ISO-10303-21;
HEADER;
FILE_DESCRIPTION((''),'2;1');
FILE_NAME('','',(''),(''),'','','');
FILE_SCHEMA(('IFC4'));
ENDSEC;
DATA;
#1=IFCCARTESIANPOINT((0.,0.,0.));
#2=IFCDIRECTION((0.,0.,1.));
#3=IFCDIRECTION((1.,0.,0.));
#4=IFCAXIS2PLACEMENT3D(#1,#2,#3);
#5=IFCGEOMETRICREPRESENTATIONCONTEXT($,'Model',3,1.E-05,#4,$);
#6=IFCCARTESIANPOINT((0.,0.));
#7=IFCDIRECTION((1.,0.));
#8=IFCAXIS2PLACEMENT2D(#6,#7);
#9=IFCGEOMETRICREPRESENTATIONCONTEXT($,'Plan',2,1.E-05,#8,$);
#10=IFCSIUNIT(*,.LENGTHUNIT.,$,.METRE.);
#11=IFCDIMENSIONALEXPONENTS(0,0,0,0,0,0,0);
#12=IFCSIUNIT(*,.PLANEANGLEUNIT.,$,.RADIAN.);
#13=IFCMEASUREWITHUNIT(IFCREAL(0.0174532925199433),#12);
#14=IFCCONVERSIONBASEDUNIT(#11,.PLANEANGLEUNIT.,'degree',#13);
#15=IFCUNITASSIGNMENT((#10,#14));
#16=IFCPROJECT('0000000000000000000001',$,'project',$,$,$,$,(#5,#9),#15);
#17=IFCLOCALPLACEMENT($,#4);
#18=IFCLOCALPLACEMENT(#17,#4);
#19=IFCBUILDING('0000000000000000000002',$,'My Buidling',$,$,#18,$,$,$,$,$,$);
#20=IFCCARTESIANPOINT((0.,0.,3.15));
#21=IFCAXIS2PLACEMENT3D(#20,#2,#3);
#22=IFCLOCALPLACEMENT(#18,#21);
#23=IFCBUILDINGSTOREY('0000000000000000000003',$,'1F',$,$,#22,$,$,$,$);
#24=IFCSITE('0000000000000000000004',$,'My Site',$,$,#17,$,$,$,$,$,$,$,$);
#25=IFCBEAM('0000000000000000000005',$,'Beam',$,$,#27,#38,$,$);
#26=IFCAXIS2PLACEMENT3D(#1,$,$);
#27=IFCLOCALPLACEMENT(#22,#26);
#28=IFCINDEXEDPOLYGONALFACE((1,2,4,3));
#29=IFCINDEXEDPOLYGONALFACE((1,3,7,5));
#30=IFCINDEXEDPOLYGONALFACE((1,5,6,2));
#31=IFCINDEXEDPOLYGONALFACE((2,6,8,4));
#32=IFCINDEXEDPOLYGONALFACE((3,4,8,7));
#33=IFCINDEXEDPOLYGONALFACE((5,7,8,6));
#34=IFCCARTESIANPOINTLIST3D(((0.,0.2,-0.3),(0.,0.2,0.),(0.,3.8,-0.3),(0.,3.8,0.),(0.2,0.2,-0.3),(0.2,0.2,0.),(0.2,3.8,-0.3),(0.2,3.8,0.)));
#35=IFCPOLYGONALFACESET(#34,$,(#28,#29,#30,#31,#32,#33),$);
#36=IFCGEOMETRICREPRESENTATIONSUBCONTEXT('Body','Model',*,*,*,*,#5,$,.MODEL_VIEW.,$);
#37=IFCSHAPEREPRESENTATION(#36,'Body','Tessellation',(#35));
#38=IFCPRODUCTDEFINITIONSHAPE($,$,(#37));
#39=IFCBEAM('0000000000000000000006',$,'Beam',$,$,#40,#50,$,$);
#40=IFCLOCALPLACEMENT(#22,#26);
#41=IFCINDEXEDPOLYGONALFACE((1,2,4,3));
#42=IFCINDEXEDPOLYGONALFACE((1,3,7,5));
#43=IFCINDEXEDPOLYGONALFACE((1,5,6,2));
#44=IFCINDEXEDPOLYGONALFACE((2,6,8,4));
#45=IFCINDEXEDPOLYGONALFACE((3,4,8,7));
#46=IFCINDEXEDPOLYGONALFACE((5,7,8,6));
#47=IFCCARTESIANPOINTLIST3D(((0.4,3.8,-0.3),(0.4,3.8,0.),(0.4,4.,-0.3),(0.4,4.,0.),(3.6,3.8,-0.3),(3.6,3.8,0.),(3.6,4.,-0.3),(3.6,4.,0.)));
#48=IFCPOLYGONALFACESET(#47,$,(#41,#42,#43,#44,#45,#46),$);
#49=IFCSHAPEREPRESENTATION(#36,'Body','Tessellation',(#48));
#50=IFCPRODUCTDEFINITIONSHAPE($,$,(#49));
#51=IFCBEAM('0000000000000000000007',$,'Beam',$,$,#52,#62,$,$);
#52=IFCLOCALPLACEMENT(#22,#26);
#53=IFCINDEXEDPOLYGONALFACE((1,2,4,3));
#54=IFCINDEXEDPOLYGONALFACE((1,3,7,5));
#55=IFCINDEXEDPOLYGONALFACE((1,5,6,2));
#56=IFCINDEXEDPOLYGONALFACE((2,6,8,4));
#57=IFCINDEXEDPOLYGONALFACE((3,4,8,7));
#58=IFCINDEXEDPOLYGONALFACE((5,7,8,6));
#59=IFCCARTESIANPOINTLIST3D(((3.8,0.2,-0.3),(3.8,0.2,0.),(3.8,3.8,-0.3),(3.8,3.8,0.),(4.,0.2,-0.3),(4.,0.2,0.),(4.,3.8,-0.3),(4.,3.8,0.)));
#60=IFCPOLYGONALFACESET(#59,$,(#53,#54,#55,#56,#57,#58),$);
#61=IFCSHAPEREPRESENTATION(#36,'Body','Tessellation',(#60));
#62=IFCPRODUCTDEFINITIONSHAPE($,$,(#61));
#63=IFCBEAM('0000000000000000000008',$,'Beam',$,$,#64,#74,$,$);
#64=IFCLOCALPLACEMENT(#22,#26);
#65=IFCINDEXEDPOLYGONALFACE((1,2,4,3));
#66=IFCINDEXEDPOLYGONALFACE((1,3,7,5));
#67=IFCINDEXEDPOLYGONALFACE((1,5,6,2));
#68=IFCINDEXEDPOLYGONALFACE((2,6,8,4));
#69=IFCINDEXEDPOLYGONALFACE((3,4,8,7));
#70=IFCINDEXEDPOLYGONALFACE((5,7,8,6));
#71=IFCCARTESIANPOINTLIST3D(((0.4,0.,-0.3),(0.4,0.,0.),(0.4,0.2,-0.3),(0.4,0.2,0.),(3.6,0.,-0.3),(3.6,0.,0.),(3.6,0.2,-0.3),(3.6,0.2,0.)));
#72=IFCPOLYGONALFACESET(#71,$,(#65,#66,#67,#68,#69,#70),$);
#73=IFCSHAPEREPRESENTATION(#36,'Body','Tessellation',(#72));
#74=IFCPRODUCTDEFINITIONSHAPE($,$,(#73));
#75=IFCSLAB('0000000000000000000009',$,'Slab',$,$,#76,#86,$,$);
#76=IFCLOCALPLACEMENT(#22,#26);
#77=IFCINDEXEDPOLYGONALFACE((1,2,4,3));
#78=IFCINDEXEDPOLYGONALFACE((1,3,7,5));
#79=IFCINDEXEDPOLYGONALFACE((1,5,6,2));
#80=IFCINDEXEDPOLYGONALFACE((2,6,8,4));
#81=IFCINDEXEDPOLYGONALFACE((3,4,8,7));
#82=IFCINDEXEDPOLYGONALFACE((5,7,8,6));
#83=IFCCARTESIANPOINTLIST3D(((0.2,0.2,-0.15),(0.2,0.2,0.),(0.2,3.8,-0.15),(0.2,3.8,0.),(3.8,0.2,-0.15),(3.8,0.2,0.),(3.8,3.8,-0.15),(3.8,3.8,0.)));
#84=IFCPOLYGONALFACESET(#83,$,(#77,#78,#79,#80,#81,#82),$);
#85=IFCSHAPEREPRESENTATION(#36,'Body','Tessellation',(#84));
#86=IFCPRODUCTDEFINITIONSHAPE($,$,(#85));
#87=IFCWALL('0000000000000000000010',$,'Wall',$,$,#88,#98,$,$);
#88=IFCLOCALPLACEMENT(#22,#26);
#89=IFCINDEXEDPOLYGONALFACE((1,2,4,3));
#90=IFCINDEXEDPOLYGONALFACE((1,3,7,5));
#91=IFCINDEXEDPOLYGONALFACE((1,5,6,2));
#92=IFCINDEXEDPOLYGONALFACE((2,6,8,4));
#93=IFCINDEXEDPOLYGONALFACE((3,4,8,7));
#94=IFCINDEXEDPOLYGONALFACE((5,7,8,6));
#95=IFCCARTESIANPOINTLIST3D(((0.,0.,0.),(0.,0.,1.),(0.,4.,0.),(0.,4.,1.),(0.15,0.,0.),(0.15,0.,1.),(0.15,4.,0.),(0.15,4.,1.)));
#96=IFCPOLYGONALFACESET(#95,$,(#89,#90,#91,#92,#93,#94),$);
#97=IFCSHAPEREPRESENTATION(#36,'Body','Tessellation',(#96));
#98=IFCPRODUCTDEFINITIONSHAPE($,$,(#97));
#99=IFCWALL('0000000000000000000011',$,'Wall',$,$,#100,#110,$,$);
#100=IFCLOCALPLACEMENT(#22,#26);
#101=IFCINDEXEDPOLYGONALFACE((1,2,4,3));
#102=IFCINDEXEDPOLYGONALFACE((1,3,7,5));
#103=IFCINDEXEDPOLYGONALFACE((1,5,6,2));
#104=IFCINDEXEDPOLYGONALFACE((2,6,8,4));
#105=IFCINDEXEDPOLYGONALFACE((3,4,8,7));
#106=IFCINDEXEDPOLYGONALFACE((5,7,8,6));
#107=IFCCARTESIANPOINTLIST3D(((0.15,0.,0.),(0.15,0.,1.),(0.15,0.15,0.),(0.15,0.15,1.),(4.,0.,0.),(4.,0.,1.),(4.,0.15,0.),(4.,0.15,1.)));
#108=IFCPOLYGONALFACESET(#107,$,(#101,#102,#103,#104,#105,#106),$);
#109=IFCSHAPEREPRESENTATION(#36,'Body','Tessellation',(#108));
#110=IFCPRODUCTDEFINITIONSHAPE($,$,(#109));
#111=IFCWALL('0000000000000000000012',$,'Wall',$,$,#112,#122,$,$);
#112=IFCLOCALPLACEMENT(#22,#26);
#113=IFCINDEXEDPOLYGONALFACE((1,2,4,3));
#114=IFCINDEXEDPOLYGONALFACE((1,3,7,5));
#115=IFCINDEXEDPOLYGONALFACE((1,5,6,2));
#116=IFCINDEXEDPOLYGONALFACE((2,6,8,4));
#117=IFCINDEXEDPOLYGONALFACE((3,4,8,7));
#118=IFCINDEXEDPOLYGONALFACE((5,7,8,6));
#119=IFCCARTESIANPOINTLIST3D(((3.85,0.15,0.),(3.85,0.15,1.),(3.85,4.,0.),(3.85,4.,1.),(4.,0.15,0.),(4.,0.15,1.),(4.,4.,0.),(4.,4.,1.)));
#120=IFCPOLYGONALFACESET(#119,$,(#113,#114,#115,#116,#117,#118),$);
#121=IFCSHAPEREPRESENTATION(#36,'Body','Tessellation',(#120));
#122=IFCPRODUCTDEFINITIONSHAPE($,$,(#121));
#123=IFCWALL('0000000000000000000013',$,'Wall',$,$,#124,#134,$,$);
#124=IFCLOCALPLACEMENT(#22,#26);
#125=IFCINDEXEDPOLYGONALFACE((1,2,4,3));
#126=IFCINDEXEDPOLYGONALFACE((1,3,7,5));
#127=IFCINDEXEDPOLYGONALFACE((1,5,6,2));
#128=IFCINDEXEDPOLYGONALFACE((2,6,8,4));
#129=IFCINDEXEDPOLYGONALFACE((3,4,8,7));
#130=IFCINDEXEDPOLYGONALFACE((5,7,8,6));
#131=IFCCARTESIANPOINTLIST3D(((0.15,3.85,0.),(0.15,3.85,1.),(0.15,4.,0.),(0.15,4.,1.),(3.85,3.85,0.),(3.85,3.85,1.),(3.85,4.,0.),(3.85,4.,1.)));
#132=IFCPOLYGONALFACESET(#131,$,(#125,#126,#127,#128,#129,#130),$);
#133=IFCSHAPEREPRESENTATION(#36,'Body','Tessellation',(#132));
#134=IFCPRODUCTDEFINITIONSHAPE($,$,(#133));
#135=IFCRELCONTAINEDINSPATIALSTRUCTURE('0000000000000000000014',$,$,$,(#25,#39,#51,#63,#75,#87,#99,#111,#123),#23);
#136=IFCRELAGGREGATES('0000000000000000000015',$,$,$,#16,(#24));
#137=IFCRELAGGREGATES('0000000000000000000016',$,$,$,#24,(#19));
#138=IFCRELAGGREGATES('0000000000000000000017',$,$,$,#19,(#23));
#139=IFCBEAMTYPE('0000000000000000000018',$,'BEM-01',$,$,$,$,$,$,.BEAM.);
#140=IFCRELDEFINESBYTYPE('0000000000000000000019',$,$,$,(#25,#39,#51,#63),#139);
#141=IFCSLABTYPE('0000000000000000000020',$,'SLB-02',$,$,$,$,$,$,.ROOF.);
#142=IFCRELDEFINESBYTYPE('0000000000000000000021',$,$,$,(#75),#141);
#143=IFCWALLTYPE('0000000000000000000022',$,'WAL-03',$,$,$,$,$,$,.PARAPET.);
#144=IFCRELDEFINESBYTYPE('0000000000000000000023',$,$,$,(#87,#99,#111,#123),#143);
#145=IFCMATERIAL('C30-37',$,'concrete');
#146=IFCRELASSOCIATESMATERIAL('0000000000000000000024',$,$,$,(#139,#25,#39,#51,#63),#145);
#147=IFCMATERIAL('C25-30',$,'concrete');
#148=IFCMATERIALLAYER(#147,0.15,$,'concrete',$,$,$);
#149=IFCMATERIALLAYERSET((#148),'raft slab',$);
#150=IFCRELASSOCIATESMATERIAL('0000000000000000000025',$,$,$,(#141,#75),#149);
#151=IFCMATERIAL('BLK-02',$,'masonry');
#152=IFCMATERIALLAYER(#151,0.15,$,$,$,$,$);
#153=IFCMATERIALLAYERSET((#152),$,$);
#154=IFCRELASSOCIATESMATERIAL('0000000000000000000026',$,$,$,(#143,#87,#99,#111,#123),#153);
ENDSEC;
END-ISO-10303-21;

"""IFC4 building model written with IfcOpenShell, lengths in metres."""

from ifc_helpers import new_model, entity, si_unit, converted_unit, frame, origin_with_axes, origin_2d_with_axis, place, context, subcontext, project, spatial, line, indexed_curve, rectangle, outline, extrude, material, layer, layer_set, layer_usage, material_profile, profile_set, profile_usage, type_object, element, save


model = new_model("IFC4")

# Units and contexts
model_context = context("Model", 3, precision=1e-05, world=origin_with_axes())
plan_context = context("Plan", 2, precision=1e-05, world=origin_2d_with_axis())
body_context = subcontext(model_context, "Body", "Model", "MODEL_VIEW")
ifc_project = project(units=[si_unit("LENGTHUNIT", "METRE"), converted_unit("PLANEANGLEUNIT", "degree", entity("IfcReal", 0.0174532925199433), si_unit("PLANEANGLEUNIT", "RADIAN"), dimensions=[0, 0, 0, 0, 0, 0, 0])], contexts=[model_context, plan_context])

# Site, building, storey
site_placement = place(None, origin_with_axes())
site = spatial("IfcSite", under=ifc_project, at=site_placement, Name="My Site")
building_placement = place(site_placement, origin_with_axes())
building = spatial("IfcBuilding", under=site, at=building_placement, Name="My Buidling")
storey_placement = place(building_placement, frame((0.0, 0.0, 3.15), z_axis=(0.0, 0.0, 1.0), x_axis=(1.0, 0.0, 0.0)))
storey = spatial("IfcBuildingStorey", under=building, at=storey_placement, Name="1F")

# Beams
ifc_material_1 = material(Name="C30-37", Category="concrete")
ifc_material_profile = material_profile(ifc_material_1, rectangle(XDim=0.2, YDim=0.3))
ifc_profile_set = profile_set([ifc_material_profile])
ifc_profile_usage_1 = profile_usage(ifc_profile_set, cardinal=7)
beam_type = type_object("IfcBeamType", Name="BEM-01", PredefinedType="BEAM", material=ifc_profile_set)
beam_1_placement = place(storey_placement, frame((0.0, 0.2, 0.0), z_axis=(0.0, 1.0, 0.0), x_axis=(-1.0, 0.0, 0.0)))
element("IfcBeam", 1, at=beam_1_placement, inside=storey, type_object=beam_type, material=ifc_profile_usage_1, Name="Beam", context=body_context, shape_type="SweptSolid", body=[
    extrude(rectangle(XDim=0.2, YDim=0.3), frame((-0.1, -0.15, 0.0), z_axis=(0.0, 0.0, 1.0), x_axis=(1.0, 0.0, 0.0)), (0.0, 0.0, 1.0), 3.6),
])
ifc_profile_usage_2 = profile_usage(ifc_profile_set, cardinal=7)
beam_2_placement = place(storey_placement, frame((0.4, 4.0, 0.0), z_axis=(1.0, 0.0, 0.0), x_axis=(0.0, 1.0, 0.0)))
element("IfcBeam", 2, at=beam_2_placement, inside=storey, type_object=beam_type, material=ifc_profile_usage_2, Name="Beam", context=body_context, shape_type="SweptSolid", body=[
    extrude(rectangle(XDim=0.2, YDim=0.3), frame((-0.1, -0.15, 0.0), z_axis=(0.0, 0.0, 1.0), x_axis=(1.0, 0.0, 0.0)), (0.0, 0.0, 1.0), 3.2),
])
ifc_profile_usage_3 = profile_usage(ifc_profile_set, cardinal=7)
beam_3_placement = place(storey_placement, frame((4.0, 3.8, 0.0), z_axis=(0.0, -1.0, 0.0), x_axis=(1.0, 0.0, 0.0)))
element("IfcBeam", 3, at=beam_3_placement, inside=storey, type_object=beam_type, material=ifc_profile_usage_3, Name="Beam", context=body_context, shape_type="SweptSolid", body=[
    extrude(rectangle(XDim=0.2, YDim=0.3), frame((-0.1, -0.15, 0.0), z_axis=(0.0, 0.0, 1.0), x_axis=(1.0, 0.0, 0.0)), (0.0, 0.0, 1.0), 3.6),
])
ifc_profile_usage_4 = profile_usage(ifc_profile_set, cardinal=7)
beam_4_placement = place(storey_placement, frame((3.6, 0.0, 0.0), z_axis=(-1.0, 0.0, 0.0), x_axis=(0.0, -1.0, 0.0)))
element("IfcBeam", 4, at=beam_4_placement, inside=storey, type_object=beam_type, material=ifc_profile_usage_4, Name="Beam", context=body_context, shape_type="SweptSolid", body=[
    extrude(rectangle(XDim=0.2, YDim=0.3), frame((-0.1, -0.15, 0.0), z_axis=(0.0, 0.0, 1.0), x_axis=(1.0, 0.0, 0.0)), (0.0, 0.0, 1.0), 3.2),
])

# Slab
ifc_material_2 = material(Name="C25-30", Category="concrete")
ifc_layer_1 = layer(ifc_material_2, 0.15, Name="concrete")
ifc_layer_set_1 = layer_set([ifc_layer_1], Name="raft slab")
ifc_layer_usage_1 = layer_usage(ifc_layer_set_1, "AXIS3", "POSITIVE", 0.0)
slab_type = type_object("IfcSlabType", Name="SLB-02", PredefinedType="ROOF", material=ifc_layer_set_1)
slab_placement = place(storey_placement, frame((3.8, 3.8, -0.15), z_axis=(0.0, 0.0, 1.0), x_axis=(-1.0, 0.0, 0.0)))
element("IfcSlab", 5, at=slab_placement, inside=storey, type_object=slab_type, material=ifc_layer_usage_1, Name="Slab", context=body_context, shape_type="SweptSolid", body=[
    extrude(outline(indexed_curve([(0.0, 0.0), (3.6, 0.0), (3.6, 3.6), (0.0, 3.6)], segments=[line(4, 1), line(1, 2), line(2, 3), line(3, 4)], self_intersect=False)), None, (0.0, 0.0, 1.0), 0.15),
])

# Walls
ifc_material_3 = material(Name="BLK-02", Category="masonry")
ifc_layer_2 = layer(ifc_material_3, 0.15)
ifc_layer_set_2 = layer_set([ifc_layer_2])
ifc_layer_usage_2 = layer_usage(ifc_layer_set_2, "AXIS2", "POSITIVE", 0.0)
wall_type = type_object("IfcWallType", Name="WAL-03", PredefinedType="PARAPET", material=ifc_layer_set_2)
wall_1_placement = place(storey_placement, frame((0.0, 4.0, 0.0), z_axis=(0.0, 0.0, 1.0), x_axis=(-0.000001, -1.0, 0.0)))
element("IfcWall", 6, at=wall_1_placement, inside=storey, type_object=wall_type, material=ifc_layer_usage_2, Name="Wall", context=body_context, shape_type="SweptSolid", body=[
    extrude(outline(indexed_curve([(0.0, 0.0), (0.0, 0.15), (4.0, 0.15), (4.0, 0.0), (0.0, 0.0)], self_intersect=False)), origin_with_axes(), (0.0, 0.0, 1.0), 1.0),
])
ifc_layer_usage_3 = layer_usage(ifc_layer_set_2, "AXIS2", "POSITIVE", 0.0)
wall_2_placement = place(storey_placement, frame((0.15, 0.0, 0.0), z_axis=(0.0, 0.0, 1.0), x_axis=(1.0, 0.0, 0.0)))
element("IfcWall", 7, at=wall_2_placement, inside=storey, type_object=wall_type, material=ifc_layer_usage_3, Name="Wall", context=body_context, shape_type="SweptSolid", body=[
    extrude(outline(indexed_curve([(0.0, 0.0), (0.0, 0.15), (3.85, 0.15), (3.85, 0.0), (0.0, 0.0)], self_intersect=False)), origin_with_axes(), (0.0, 0.0, 1.0), 1.0),
])
ifc_layer_usage_4 = layer_usage(ifc_layer_set_2, "AXIS2", "POSITIVE", 0.0)
wall_3_placement = place(storey_placement, frame((4.0, 0.15, 0.0), z_axis=(0.0, 0.0, 1.0), x_axis=(0.000001, 1.0, 0.0)))
element("IfcWall", 8, at=wall_3_placement, inside=storey, type_object=wall_type, material=ifc_layer_usage_4, Name="Wall", context=body_context, shape_type="SweptSolid", body=[
    extrude(outline(indexed_curve([(0.0, 0.0), (0.0, 0.15), (3.85, 0.15), (3.85, 0.0), (0.0, 0.0)], self_intersect=False)), origin_with_axes(), (0.0, 0.0, 1.0), 1.0),
])
ifc_layer_usage_5 = layer_usage(ifc_layer_set_2, "AXIS2", "POSITIVE", 0.0)
wall_4_placement = place(storey_placement, frame((3.85, 4.0, 0.0), z_axis=(0.0, 0.0, 1.0), x_axis=(-1.0, 0.0, 0.0)))
element("IfcWall", 9, at=wall_4_placement, inside=storey, type_object=wall_type, material=ifc_layer_usage_5, Name="Wall", context=body_context, shape_type="SweptSolid", body=[
    extrude(outline(indexed_curve([(0.0, 0.0), (0.0, 0.15), (3.7, 0.15), (3.7, 0.0), (0.0, 0.0)], self_intersect=False)), origin_with_axes(), (0.0, 0.0, 1.0), 1.0),
])

save(model, "model.ifc")
